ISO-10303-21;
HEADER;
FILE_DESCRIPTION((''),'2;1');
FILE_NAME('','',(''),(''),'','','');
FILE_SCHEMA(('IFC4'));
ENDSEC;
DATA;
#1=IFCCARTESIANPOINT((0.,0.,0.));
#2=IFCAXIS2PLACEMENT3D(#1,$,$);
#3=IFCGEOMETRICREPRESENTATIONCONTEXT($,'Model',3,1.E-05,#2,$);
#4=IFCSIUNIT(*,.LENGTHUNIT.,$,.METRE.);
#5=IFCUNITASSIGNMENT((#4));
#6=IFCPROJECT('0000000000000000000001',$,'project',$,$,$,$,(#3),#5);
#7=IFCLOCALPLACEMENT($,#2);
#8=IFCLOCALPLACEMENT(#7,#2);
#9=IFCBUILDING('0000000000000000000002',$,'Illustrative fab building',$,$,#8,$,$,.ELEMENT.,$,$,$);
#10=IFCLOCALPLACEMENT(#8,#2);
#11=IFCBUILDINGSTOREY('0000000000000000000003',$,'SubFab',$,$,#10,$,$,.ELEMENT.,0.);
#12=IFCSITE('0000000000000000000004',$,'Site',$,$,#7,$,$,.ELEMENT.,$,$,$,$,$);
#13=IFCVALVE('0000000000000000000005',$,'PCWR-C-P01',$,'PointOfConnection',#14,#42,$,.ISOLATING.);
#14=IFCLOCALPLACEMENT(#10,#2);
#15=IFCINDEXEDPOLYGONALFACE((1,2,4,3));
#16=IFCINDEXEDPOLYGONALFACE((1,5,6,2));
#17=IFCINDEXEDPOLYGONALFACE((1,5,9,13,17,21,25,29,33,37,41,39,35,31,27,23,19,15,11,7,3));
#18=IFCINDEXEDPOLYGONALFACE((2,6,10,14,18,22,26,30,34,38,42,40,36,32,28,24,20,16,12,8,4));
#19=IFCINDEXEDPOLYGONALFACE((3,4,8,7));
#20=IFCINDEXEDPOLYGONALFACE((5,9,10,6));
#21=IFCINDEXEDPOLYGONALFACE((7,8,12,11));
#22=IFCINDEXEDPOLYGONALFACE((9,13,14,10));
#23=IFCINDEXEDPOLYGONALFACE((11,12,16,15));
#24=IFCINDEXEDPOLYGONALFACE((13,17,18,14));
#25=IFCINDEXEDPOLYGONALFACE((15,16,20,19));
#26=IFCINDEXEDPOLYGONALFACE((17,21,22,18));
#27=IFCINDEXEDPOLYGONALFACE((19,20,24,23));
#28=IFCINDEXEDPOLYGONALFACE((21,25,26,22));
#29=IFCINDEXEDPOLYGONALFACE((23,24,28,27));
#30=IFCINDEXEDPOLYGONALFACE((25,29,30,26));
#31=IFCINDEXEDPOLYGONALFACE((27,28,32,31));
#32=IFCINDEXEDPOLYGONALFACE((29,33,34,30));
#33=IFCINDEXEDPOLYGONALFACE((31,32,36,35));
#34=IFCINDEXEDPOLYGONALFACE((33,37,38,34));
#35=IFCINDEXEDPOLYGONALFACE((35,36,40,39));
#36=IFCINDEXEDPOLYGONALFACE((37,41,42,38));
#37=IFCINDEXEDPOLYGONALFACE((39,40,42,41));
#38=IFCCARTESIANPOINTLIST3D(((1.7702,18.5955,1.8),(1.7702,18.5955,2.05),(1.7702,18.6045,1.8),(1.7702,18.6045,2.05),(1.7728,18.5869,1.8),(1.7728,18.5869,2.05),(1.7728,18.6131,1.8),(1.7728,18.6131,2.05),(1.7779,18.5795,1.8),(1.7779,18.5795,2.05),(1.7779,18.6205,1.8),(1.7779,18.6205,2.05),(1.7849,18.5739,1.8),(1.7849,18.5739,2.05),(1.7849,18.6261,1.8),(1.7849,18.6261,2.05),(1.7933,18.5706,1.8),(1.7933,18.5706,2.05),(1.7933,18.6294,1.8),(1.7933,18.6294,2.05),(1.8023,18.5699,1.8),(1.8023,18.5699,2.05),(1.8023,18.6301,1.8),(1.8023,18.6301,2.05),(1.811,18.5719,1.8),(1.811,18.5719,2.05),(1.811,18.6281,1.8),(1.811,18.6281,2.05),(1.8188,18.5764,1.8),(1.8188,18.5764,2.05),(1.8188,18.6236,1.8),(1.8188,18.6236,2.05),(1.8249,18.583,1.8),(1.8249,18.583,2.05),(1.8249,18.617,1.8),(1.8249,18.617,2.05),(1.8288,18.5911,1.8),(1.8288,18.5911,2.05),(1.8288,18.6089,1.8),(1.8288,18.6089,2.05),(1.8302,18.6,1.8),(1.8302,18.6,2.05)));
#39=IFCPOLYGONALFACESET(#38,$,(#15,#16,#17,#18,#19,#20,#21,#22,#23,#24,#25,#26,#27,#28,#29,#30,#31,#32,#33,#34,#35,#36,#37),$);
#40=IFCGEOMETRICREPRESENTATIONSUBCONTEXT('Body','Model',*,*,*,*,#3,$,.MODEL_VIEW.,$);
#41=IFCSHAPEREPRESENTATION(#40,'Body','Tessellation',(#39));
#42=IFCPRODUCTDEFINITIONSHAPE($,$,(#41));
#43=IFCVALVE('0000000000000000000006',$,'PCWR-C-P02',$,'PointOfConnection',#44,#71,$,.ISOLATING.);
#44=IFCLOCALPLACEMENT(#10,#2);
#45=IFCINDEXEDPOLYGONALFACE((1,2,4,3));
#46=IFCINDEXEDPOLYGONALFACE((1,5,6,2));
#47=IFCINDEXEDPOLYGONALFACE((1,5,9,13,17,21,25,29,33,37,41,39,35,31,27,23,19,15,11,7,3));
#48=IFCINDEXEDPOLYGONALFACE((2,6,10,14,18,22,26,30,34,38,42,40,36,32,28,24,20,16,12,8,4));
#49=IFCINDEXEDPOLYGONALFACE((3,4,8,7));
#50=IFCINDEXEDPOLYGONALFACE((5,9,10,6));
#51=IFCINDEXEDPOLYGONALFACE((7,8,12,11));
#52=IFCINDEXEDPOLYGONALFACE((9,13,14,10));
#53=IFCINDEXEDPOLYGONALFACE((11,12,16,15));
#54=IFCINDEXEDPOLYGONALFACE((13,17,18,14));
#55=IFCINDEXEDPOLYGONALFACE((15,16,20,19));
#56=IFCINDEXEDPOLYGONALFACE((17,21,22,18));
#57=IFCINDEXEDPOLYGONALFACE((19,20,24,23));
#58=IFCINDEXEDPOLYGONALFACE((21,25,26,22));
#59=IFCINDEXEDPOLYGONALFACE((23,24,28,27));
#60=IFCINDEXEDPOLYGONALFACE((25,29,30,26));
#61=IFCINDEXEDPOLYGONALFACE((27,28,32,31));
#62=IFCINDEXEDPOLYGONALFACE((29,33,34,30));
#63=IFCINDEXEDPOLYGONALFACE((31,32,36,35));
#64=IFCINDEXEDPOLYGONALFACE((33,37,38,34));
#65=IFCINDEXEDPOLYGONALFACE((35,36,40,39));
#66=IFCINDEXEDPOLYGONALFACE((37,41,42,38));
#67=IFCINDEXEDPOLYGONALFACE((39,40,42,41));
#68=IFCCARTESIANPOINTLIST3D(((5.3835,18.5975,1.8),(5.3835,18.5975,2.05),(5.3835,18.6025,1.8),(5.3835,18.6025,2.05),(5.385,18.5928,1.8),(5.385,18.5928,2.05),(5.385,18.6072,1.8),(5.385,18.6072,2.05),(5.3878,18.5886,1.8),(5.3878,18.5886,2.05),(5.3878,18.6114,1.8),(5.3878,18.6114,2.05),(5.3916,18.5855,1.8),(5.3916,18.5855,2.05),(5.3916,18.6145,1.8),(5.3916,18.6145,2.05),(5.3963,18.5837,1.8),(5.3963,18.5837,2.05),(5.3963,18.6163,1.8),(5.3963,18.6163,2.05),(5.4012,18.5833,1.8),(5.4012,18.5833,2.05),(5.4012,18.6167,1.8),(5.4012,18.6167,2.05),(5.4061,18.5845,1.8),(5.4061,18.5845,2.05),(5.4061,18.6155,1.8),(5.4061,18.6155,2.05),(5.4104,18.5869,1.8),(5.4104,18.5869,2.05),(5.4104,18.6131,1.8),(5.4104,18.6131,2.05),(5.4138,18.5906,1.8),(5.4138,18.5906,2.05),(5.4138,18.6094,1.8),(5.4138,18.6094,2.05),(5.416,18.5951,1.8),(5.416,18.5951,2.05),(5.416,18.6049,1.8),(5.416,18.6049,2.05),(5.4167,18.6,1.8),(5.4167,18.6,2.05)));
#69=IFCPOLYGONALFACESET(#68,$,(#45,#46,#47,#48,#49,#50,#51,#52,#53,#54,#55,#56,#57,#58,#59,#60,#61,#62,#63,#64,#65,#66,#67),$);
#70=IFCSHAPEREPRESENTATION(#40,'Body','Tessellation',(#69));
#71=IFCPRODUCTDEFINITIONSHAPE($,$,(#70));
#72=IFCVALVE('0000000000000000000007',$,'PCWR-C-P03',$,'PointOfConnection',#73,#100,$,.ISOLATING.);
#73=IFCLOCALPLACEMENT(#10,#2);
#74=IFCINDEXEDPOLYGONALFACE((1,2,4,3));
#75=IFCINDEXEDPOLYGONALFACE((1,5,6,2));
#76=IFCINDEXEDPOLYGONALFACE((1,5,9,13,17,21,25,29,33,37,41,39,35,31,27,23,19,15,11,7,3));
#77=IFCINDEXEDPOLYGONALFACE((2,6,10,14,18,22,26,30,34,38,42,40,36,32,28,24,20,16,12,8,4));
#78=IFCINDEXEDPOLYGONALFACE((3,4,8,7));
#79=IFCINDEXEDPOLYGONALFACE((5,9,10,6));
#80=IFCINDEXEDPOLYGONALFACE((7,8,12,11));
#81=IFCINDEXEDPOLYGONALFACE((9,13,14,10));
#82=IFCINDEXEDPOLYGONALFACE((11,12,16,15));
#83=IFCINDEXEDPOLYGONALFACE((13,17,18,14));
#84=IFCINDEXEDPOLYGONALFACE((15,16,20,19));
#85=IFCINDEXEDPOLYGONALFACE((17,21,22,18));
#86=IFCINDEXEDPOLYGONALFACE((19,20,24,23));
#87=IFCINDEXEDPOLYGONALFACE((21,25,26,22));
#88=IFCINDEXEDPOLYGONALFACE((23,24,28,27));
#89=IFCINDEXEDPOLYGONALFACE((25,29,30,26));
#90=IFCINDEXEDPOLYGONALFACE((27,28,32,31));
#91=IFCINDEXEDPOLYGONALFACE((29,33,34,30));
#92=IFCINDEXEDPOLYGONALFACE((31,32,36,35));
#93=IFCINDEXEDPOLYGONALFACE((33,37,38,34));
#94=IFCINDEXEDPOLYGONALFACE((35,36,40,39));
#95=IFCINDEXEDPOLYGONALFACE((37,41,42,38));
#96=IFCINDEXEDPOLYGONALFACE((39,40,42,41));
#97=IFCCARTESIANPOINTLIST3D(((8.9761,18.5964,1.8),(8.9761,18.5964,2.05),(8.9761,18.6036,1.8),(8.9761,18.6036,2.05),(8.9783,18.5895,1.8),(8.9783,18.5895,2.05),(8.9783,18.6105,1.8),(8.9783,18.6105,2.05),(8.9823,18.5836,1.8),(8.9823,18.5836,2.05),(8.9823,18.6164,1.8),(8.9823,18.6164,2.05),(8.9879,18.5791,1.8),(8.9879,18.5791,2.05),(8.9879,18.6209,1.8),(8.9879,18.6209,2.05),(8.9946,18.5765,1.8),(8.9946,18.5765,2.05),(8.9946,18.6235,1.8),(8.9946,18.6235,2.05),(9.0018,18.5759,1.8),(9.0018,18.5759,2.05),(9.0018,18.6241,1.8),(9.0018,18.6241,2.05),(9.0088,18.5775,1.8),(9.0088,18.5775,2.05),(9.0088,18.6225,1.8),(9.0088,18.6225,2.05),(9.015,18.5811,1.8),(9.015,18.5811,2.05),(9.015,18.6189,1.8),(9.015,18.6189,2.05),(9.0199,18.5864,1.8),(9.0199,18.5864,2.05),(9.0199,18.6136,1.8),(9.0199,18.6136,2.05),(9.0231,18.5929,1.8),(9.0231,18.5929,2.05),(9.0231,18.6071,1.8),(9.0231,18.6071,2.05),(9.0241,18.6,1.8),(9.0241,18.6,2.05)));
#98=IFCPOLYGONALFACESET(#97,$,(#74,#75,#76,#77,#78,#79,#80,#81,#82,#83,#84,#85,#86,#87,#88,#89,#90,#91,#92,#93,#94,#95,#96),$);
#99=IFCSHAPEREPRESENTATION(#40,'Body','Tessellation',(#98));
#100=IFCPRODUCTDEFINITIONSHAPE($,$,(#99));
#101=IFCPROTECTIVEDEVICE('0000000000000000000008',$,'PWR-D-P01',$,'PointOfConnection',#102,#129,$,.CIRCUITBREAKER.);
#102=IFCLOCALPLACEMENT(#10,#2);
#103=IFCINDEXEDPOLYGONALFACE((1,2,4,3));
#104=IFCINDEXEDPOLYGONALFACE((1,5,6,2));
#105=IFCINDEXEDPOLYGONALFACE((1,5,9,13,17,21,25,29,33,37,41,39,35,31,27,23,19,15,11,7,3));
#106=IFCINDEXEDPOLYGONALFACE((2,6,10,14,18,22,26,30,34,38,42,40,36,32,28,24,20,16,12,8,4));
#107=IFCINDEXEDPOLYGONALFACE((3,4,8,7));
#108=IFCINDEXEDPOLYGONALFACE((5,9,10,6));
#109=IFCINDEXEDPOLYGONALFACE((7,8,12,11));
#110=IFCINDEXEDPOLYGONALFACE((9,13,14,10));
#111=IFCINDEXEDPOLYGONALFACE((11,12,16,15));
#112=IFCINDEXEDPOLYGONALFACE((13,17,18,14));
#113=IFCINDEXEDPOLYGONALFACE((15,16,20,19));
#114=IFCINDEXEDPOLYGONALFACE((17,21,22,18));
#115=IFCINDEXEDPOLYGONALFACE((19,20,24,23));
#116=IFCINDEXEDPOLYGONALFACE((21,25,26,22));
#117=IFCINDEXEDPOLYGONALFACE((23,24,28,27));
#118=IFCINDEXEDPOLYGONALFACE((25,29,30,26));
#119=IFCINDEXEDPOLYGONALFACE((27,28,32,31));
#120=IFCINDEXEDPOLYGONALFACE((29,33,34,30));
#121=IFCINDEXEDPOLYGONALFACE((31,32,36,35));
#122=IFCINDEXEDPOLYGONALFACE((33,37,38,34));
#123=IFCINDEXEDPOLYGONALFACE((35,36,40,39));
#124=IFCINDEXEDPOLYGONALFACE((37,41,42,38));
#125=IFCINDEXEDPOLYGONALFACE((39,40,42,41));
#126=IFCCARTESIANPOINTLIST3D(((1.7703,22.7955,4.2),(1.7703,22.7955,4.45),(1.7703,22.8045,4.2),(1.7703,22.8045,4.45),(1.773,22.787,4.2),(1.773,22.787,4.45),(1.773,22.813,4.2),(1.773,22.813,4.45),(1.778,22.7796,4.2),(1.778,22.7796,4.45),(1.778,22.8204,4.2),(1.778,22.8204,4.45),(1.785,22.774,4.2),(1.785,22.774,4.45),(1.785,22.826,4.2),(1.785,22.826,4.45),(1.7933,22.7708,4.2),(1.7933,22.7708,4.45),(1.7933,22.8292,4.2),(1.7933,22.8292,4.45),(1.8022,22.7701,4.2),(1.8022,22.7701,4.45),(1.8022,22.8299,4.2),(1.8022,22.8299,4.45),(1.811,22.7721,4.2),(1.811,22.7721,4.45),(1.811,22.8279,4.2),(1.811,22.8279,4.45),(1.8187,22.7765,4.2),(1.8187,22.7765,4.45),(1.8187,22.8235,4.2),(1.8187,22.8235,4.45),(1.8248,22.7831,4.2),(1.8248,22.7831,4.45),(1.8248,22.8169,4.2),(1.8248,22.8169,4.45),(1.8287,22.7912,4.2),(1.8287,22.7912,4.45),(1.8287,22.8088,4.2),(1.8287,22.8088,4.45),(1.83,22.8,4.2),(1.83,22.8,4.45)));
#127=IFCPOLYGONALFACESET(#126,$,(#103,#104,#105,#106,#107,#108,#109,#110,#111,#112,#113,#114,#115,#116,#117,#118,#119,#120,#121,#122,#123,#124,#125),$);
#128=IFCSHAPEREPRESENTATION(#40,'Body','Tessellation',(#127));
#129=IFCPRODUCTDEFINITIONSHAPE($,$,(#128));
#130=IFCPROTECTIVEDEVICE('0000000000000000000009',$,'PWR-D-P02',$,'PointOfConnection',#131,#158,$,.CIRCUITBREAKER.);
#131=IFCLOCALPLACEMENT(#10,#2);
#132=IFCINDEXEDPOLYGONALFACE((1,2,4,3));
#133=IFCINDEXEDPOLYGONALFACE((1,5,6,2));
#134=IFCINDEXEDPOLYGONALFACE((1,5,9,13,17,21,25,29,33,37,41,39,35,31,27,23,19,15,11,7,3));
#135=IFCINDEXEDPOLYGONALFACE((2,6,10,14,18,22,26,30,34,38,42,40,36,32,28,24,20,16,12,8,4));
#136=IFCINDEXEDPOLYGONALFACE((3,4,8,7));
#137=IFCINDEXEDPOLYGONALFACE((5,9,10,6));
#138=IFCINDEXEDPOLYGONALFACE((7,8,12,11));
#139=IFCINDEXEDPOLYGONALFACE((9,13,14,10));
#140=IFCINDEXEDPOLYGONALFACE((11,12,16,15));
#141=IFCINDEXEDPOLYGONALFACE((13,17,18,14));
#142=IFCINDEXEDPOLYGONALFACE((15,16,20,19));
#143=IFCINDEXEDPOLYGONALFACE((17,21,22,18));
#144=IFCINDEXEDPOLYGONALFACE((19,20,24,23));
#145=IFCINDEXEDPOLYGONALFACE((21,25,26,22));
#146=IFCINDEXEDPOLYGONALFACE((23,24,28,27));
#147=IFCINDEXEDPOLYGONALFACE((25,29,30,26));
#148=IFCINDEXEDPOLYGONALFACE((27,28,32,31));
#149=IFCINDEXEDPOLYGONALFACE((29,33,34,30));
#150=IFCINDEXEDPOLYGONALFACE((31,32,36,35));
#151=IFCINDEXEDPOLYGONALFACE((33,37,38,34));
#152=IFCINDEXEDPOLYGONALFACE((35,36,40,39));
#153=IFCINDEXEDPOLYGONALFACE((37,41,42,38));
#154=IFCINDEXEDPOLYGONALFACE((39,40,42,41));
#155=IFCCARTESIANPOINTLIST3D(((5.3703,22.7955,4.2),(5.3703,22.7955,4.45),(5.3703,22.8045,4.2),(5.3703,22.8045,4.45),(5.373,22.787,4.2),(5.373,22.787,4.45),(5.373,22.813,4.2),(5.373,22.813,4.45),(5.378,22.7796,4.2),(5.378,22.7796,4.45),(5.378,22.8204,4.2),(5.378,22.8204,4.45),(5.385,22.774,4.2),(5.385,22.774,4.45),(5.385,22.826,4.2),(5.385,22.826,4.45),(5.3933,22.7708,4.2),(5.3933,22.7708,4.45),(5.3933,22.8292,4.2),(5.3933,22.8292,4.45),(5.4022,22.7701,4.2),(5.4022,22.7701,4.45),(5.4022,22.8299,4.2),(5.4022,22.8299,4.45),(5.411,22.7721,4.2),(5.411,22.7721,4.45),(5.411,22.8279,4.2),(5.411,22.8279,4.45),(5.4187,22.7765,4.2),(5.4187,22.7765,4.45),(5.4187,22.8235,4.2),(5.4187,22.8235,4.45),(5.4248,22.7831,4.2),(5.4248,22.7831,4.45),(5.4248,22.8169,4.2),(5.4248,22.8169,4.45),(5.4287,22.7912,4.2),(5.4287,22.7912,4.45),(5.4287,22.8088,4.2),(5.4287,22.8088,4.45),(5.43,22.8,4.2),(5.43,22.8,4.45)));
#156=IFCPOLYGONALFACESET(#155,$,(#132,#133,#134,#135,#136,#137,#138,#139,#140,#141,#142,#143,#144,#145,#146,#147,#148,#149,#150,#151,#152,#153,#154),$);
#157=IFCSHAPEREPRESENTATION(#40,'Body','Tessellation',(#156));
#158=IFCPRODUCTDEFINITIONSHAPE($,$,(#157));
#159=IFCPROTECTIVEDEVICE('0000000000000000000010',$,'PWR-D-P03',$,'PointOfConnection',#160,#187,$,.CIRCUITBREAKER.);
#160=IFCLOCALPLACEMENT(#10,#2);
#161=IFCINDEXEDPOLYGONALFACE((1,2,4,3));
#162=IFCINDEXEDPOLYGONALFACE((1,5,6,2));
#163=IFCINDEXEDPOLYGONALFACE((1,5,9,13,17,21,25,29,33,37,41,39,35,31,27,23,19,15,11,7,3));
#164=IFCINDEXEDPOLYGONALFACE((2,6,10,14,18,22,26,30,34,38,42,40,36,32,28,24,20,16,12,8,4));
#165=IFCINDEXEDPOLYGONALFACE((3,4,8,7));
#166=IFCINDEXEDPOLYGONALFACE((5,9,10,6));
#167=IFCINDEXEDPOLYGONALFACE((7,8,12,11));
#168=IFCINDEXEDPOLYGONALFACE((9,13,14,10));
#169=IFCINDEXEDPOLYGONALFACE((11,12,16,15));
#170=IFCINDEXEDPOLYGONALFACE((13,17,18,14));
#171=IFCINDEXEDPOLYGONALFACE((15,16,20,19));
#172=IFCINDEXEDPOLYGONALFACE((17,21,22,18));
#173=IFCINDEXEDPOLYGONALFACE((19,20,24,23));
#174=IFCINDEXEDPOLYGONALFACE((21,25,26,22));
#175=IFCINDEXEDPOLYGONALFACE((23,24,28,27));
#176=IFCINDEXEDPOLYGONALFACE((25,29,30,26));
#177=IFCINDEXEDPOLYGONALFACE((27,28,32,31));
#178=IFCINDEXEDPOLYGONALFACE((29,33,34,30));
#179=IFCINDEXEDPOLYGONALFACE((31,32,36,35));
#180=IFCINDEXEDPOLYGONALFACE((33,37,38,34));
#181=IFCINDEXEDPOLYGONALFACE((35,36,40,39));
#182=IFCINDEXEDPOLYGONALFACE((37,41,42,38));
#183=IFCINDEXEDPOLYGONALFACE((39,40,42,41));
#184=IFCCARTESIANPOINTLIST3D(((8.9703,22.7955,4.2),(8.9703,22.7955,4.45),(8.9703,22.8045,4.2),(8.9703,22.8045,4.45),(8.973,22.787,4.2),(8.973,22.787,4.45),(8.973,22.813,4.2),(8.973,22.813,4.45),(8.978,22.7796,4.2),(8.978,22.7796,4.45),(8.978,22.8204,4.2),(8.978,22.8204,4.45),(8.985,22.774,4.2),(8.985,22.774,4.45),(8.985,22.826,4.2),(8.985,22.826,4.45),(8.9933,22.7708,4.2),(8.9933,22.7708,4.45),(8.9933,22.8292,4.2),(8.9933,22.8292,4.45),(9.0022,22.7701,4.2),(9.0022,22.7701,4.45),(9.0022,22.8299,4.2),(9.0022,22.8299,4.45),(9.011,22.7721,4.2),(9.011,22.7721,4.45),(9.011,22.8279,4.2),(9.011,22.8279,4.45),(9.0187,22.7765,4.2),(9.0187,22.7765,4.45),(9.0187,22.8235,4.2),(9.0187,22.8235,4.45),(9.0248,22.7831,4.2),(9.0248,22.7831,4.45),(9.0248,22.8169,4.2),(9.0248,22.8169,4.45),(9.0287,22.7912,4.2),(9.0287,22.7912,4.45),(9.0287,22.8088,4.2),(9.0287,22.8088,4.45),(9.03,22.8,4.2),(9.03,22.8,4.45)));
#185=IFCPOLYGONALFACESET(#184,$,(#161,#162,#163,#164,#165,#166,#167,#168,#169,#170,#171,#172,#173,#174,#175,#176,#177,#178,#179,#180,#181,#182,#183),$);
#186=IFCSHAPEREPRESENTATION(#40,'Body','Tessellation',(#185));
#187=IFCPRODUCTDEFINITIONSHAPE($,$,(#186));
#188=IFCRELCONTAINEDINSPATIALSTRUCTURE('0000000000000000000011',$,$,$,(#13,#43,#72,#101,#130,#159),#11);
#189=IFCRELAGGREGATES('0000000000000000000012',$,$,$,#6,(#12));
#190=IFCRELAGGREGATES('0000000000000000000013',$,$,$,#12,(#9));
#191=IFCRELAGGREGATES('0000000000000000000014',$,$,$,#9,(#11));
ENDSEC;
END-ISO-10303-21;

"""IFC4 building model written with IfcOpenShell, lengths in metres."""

from ifc_helpers import new_model, entity, si_unit, frame, origin, place, context, subcontext, project, spatial, element, save


model = new_model("IFC4")

# Units and contexts
model_context = context("Model", 3, precision=1e-05, world=origin())
body_context = subcontext(model_context, "Body", "Model", "MODEL_VIEW")
ifc_project = project(units=[si_unit("LENGTHUNIT", "METRE")], contexts=[model_context])

# Site, building, storey
site_placement = place(None, origin())
site = spatial("IfcSite", under=ifc_project, at=site_placement, Name="Site", CompositionType="ELEMENT")
building_placement = place(site_placement, origin())
building = spatial("IfcBuilding", under=site, at=building_placement, Name="Illustrative fab building", CompositionType="ELEMENT")
storey_placement = place(building_placement, origin())
storey = spatial("IfcBuildingStorey", under=building, at=storey_placement, Name="SubFab", CompositionType="ELEMENT", Elevation=0.0)

# Valves
valve_1_placement = place(storey_placement, frame((1.8, 18.6, 1.8)))
element("IfcValve", 1, at=valve_1_placement, inside=storey, Name="PCWR-C-P01", ObjectType="PointOfConnection", PredefinedType="ISOLATING", context=body_context, shape_type="AdvancedSweptSolid", body=[
    entity("IfcSweptDiskSolid", entity("IfcPolyline", [entity("IfcCartesianPoint", [0.0, 0.0, 0.0]), entity("IfcCartesianPoint", [0.0, 0.0, 0.25])]), 0.0302),
])
valve_2_placement = place(storey_placement, frame((5.4, 18.6, 1.8)))
element("IfcValve", 2, at=valve_2_placement, inside=storey, Name="PCWR-C-P02", ObjectType="PointOfConnection", PredefinedType="ISOLATING", context=body_context, shape_type="AdvancedSweptSolid", body=[
    entity("IfcSweptDiskSolid", entity("IfcPolyline", [entity("IfcCartesianPoint", [0.0, 0.0, 0.0]), entity("IfcCartesianPoint", [0.0, 0.0, 0.25])]), 0.0167),
])
valve_3_placement = place(storey_placement, frame((9.0, 18.6, 1.8)))
element("IfcValve", 3, at=valve_3_placement, inside=storey, Name="PCWR-C-P03", ObjectType="PointOfConnection", PredefinedType="ISOLATING", context=body_context, shape_type="AdvancedSweptSolid", body=[
    entity("IfcSweptDiskSolid", entity("IfcPolyline", [entity("IfcCartesianPoint", [0.0, 0.0, 0.0]), entity("IfcCartesianPoint", [0.0, 0.0, 0.25])]), 0.0241),
])

# Protective devices
for number, where, name in (
    (4, (1.8, 22.8, 4.2), "PWR-D-P01"),
    (5, (5.4, 22.8, 4.2), "PWR-D-P02"),
    (6, (9.0, 22.8, 4.2), "PWR-D-P03"),
):
    element("IfcProtectiveDevice", number, at=place(storey_placement, frame(where)), inside=storey, Name=name, ObjectType="PointOfConnection", PredefinedType="CIRCUITBREAKER", context=body_context, shape_type="AdvancedSweptSolid", body=[
        entity("IfcSweptDiskSolid", entity("IfcPolyline", [entity("IfcCartesianPoint", [0.0, 0.0, 0.0]), entity("IfcCartesianPoint", [0.0, 0.0, 0.25])]), 0.03),
    ])

save(model, "model.ifc")
